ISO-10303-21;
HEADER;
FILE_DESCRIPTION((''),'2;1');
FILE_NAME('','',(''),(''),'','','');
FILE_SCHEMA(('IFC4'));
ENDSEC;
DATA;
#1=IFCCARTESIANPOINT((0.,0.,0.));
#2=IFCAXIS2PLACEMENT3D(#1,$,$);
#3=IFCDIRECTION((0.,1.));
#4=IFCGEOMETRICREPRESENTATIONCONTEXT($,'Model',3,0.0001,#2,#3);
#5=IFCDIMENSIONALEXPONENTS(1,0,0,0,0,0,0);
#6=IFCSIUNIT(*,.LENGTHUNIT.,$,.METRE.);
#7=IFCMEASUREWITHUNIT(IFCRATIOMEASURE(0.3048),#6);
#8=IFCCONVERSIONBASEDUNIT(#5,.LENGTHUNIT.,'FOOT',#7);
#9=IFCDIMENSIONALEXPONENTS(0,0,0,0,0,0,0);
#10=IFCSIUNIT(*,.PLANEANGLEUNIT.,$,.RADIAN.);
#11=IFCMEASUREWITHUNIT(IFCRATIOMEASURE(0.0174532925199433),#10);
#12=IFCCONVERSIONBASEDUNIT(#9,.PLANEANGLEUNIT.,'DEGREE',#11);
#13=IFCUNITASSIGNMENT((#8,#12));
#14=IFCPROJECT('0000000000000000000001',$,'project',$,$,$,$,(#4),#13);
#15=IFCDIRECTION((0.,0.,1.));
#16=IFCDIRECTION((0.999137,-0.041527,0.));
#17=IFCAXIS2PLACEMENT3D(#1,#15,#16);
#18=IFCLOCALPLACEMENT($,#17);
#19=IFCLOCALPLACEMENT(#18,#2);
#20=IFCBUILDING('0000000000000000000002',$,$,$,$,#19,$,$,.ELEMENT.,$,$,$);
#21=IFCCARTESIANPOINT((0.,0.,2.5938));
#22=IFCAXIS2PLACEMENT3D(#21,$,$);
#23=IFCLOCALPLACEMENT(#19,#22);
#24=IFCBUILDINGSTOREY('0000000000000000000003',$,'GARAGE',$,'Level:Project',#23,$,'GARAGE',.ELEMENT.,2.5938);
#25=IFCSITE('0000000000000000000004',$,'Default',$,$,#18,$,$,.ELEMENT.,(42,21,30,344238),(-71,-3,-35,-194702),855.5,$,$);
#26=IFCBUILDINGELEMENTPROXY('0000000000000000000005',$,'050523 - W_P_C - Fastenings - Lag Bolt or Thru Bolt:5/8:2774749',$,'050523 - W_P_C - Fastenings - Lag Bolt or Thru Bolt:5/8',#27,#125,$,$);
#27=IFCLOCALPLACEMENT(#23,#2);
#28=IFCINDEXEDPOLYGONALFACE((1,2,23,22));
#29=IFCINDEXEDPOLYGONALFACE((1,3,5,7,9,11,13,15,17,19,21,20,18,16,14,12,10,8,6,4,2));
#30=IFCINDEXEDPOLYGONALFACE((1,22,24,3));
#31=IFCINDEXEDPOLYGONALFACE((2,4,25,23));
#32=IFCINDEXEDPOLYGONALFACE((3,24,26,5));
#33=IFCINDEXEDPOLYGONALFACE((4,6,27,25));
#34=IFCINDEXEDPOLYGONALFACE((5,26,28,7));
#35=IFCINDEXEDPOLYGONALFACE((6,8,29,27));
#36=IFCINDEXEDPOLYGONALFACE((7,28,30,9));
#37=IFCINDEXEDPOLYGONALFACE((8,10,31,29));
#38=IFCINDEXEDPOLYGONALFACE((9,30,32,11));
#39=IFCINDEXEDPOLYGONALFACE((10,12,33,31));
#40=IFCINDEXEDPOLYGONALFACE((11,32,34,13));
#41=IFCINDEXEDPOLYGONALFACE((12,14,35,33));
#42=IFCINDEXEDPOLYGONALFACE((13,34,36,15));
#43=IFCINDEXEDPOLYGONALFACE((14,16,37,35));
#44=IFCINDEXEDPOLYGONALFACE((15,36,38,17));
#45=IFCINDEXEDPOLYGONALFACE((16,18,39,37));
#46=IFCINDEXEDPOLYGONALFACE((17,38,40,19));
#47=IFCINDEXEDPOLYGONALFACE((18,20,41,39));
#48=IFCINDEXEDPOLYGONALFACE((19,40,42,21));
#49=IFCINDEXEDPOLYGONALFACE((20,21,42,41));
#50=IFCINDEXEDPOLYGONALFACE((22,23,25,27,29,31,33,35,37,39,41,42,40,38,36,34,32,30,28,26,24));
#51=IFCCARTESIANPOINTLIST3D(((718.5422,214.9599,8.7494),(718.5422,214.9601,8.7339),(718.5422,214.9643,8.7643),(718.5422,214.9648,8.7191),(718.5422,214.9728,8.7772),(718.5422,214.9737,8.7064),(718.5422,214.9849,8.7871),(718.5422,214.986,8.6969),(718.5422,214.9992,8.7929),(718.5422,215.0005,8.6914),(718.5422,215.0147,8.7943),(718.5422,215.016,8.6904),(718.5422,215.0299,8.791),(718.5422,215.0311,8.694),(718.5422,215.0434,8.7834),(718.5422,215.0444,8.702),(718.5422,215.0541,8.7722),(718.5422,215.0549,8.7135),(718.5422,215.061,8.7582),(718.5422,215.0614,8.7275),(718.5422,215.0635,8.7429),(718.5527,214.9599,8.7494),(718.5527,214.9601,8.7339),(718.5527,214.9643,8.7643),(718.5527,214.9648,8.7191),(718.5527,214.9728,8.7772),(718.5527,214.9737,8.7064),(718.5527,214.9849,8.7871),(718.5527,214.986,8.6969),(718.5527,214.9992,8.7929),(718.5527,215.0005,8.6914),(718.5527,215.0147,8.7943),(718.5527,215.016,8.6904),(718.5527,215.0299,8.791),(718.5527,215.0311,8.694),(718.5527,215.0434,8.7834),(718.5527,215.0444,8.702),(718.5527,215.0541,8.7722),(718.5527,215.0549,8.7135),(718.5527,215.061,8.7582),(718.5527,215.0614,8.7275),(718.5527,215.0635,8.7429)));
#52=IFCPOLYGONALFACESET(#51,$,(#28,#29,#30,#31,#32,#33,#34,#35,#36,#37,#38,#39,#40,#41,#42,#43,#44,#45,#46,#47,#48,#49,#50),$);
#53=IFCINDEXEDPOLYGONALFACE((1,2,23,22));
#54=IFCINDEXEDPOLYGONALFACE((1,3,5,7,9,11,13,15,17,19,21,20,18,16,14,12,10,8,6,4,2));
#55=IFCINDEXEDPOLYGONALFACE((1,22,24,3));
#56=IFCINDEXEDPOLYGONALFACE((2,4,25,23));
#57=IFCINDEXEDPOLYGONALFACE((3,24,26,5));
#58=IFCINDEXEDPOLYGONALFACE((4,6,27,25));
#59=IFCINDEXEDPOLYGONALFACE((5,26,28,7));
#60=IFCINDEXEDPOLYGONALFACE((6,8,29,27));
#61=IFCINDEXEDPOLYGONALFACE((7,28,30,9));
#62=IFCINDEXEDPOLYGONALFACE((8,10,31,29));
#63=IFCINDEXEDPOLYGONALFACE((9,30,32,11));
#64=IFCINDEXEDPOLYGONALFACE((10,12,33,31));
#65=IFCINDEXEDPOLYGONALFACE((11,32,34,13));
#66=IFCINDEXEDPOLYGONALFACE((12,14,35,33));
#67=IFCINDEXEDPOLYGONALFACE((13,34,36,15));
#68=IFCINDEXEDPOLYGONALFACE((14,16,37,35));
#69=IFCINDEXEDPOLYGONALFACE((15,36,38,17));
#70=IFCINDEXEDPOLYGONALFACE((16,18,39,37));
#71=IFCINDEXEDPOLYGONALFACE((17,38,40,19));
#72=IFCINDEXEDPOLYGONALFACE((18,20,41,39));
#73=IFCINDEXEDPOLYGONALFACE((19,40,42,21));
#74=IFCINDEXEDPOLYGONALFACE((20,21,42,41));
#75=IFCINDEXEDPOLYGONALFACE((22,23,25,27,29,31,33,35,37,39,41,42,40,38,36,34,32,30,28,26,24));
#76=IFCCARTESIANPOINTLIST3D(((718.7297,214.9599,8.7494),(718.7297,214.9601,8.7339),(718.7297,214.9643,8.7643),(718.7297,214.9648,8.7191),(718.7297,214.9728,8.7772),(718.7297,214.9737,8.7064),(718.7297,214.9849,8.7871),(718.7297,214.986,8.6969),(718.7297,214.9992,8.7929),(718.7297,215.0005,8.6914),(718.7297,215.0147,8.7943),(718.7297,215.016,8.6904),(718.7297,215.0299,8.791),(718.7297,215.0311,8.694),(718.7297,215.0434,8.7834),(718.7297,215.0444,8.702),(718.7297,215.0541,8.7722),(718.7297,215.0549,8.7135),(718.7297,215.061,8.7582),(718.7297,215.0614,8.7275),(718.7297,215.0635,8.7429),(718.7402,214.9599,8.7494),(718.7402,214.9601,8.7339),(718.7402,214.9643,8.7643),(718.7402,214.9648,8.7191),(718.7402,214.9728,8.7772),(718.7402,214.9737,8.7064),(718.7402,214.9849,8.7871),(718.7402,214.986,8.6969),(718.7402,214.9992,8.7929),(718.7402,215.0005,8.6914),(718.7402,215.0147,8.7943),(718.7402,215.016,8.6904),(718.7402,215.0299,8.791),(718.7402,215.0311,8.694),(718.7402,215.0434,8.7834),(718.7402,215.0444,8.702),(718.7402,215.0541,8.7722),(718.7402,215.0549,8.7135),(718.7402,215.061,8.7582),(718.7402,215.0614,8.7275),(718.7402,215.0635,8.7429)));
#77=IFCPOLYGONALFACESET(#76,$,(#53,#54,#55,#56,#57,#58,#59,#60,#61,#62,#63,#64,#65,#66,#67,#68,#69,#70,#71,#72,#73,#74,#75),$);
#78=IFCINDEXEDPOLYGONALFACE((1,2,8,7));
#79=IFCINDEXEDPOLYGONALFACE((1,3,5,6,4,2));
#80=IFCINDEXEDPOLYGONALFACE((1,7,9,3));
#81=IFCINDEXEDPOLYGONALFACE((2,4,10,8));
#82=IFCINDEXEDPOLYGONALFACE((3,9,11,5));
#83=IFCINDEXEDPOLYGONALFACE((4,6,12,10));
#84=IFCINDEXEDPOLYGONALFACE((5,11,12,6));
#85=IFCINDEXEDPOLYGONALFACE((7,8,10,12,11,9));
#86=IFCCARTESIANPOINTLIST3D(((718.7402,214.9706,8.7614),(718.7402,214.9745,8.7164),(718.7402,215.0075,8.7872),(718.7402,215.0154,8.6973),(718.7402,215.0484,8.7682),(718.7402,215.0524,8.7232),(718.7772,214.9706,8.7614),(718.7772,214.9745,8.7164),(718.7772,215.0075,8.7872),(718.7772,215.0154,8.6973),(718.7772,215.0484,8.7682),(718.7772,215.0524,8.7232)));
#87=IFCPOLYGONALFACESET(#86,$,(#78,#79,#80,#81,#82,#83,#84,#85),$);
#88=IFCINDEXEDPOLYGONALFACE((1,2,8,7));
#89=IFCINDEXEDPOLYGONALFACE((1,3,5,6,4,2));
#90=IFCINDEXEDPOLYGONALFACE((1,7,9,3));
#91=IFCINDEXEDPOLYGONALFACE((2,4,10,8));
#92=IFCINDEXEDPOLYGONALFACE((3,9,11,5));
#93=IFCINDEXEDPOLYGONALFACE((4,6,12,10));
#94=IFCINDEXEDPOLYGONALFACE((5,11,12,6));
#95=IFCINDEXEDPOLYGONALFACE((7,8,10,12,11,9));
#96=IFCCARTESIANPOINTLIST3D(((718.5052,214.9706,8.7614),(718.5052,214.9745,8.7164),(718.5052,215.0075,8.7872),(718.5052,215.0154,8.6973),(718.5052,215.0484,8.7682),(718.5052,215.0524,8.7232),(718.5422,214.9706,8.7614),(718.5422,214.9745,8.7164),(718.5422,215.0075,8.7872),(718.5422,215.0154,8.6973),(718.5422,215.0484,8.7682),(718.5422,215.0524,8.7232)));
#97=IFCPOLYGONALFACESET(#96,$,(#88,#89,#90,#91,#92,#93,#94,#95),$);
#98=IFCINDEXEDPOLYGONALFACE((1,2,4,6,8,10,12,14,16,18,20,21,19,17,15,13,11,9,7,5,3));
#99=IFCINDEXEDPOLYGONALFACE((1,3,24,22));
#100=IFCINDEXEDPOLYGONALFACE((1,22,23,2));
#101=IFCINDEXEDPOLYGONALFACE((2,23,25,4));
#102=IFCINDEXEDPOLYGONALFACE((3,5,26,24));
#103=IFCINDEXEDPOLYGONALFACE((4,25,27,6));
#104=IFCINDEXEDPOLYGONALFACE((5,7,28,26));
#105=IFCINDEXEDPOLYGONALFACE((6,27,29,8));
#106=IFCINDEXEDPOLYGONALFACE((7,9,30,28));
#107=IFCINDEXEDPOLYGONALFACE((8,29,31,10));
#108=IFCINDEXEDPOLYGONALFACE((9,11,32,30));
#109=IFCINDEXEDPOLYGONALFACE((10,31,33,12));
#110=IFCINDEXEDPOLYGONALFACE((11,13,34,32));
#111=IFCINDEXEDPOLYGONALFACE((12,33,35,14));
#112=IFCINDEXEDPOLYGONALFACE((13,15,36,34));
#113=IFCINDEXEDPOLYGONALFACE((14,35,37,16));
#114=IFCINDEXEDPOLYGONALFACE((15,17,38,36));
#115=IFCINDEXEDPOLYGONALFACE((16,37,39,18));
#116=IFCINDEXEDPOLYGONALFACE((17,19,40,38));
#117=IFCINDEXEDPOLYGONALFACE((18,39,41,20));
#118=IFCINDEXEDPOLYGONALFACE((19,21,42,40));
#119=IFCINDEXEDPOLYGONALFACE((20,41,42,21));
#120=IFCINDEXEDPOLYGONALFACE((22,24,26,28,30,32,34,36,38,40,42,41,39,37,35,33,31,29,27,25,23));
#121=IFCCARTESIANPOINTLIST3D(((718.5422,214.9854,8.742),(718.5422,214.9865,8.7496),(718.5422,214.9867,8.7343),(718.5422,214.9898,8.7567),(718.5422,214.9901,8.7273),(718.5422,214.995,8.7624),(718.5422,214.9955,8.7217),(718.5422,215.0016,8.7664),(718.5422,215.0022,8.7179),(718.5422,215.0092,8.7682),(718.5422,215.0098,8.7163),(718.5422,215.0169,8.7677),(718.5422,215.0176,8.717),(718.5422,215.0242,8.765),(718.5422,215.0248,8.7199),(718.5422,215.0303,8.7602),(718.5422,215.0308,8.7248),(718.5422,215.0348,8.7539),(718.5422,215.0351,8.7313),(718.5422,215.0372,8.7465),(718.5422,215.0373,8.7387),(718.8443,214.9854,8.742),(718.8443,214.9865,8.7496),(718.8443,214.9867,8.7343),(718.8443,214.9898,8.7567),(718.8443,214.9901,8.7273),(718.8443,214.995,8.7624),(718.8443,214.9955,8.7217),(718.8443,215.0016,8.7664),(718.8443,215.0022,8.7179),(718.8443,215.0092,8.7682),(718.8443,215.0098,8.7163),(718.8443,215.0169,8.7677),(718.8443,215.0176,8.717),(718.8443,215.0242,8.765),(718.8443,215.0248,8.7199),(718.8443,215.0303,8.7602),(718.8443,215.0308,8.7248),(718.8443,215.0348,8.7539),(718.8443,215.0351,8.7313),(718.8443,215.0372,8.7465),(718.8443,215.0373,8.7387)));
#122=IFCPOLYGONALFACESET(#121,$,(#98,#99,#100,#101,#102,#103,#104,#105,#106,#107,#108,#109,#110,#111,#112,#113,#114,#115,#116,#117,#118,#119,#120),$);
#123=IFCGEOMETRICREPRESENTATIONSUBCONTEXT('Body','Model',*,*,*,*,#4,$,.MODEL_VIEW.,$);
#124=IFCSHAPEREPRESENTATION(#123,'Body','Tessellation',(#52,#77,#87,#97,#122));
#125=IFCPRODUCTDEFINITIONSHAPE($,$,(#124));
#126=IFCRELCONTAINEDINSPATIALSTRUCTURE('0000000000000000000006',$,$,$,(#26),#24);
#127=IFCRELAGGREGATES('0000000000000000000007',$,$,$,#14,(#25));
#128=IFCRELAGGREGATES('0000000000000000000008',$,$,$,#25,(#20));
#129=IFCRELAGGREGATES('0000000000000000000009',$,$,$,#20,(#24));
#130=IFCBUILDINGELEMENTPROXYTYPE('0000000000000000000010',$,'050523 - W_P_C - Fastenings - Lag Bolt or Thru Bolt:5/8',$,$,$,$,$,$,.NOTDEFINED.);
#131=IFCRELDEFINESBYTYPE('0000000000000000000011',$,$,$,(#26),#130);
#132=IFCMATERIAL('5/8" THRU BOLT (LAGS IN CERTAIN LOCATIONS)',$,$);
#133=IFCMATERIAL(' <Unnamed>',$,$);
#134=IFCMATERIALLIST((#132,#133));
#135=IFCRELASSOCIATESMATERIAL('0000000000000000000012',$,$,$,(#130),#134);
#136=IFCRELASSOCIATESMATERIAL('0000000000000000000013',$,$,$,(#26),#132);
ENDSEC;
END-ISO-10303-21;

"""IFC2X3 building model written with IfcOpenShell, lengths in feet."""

from ifc_helpers import new_model, entity, si_unit, converted_unit, direction, frame, frame_2d, origin, place, context, subcontext, project, spatial, polyline, circle, outline, extrude, source, transform, mapped, material, material_list, type_object, type_shapes, element, save


model = new_model("IFC2X3")

# Units and contexts
model_context = context("Model", 3, precision=0.0001, world=origin(), true_north=direction((0.0, 1.0)))
body_context = subcontext(model_context, "Body", "Model", "MODEL_VIEW")
ifc_project = project(units=[converted_unit("LENGTHUNIT", "FOOT", entity("IfcRatioMeasure", 0.3048), si_unit("LENGTHUNIT", "METRE"), dimensions=[1, 0, 0, 0, 0, 0, 0]), converted_unit("PLANEANGLEUNIT", "DEGREE", entity("IfcRatioMeasure", 0.0174532925199433), si_unit("PLANEANGLEUNIT", "RADIAN"), dimensions=[0, 0, 0, 0, 0, 0, 0])], contexts=[model_context])

# Site, building, storey
site_placement = place(None, frame((0.0, 0.0, 0.0), z_axis=(0.0, 0.0, 1.0), x_axis=(0.999137, -0.041527, 0.0)))
site = spatial("IfcSite", under=ifc_project, at=site_placement, Name="Default", CompositionType="ELEMENT", RefLatitude=(42, 21, 30, 344238), RefLongitude=(-71, -3, -35, -194702), RefElevation=855.5)
building_placement = place(site_placement, origin())
building = spatial("IfcBuilding", under=site, at=building_placement, CompositionType="ELEMENT")
storey_placement = place(building_placement, frame((0.0, 0.0, 2.5938)))
storey = spatial("IfcBuildingStorey", under=building, at=storey_placement, Name="GARAGE", ObjectType="Level:Project", LongName="GARAGE", CompositionType="ELEMENT", Elevation=2.5938)

# Building element proxy
ifc_material_1 = material(Name="5/8\" THRU BOLT (LAGS IN CERTAIN LOCATIONS)")
ifc_material_2 = material(Name=" <Unnamed>")
ifc_material_list_1 = material_list([ifc_material_1, ifc_material_2])
building_element_proxy_type_1 = type_object("IfcBuildingElementProxyType", Name="050523 - W_P_C - Fastenings - Lag Bolt or Thru Bolt:5/8", PredefinedType="NOTDEFINED", material=ifc_material_list_1)
shared_shape_1 = source(origin(), body_context, "Body", "SweptSolid", [
    extrude(circle(Radius=0.0521, at=frame_2d((0.0, 0.0), x_axis=(1.0, 0.0))), frame((0.0, 0.0, 0.0), z_axis=(0.0, 0.0, 1.0), x_axis=(0.0, -1.0, 0.0)), (0.0, 0.0, 1.0), 0.0104),
    extrude(circle(Radius=0.0521, at=frame_2d((0.0, 0.0), x_axis=(1.0, 0.0))), frame((0.0, 0.0, -0.1875), z_axis=(0.0, 0.0, 1.0), x_axis=(0.0, -1.0, 0.0)), (0.0, 0.0, 1.0), 0.0104),
    extrude(outline(polyline([(-0.0226, -0.0391), (0.0226, -0.0391), (0.0451, 0.0), (0.0226, 0.0391), (-0.0226, 0.0391), (-0.0451, 0.0), (-0.0226, -0.0391)])), frame((0.0, 0.0, -0.2245), z_axis=(0.0, 0.0, 1.0), x_axis=(0.866025, -0.5, 0.0)), (0.0, 0.0, 1.0), 0.037),
    extrude(outline(polyline([(-0.0226, -0.0391), (0.0226, -0.0391), (0.0451, 0.0), (0.0226, 0.0391), (-0.0226, 0.0391), (-0.0451, 0.0), (-0.0226, -0.0391)])), frame((0.0, 0.0, 0.0104), z_axis=(0.0, 0.0, 1.0), x_axis=(0.0, -1.0, 0.0)), (0.0, 0.0, 1.0), 0.037),
    extrude(circle(Radius=0.026, at=frame_2d((0.0, 0.0), x_axis=(1.0, 0.0))), frame((0.0, 0.0, -0.2917), z_axis=(0.0, 0.0, 1.0), x_axis=(0.0, 1.0, 0.0)), (0.0, 0.0, 1.0), 0.3021),
])
type_shapes(building_element_proxy_type_1, [shared_shape_1])
for number, where, z_axis, x_axis, name in (
    (1, (718.5527, 215.0115, 8.7423), (-1.0, 0.0, 0.0), (0.0, -0.996195, -0.087156), "050523 - W_P_C - Fastenings - Lag Bolt or Thru Bolt:5/8:2774749"),
):
    element("IfcBuildingElementProxy", number, at=place(storey_placement, frame(where, z_axis=z_axis, x_axis=x_axis)), inside=storey, type_object=building_element_proxy_type_1, material=ifc_material_1, Name=name, ObjectType="050523 - W_P_C - Fastenings - Lag Bolt or Thru Bolt:5/8", context=body_context, shape_type="MappedRepresentation", body=[
        mapped(shared_shape_1, transform((0.0, 0.0, 0.0), scale=1.0)),
    ])

save(model, "model.ifc")
